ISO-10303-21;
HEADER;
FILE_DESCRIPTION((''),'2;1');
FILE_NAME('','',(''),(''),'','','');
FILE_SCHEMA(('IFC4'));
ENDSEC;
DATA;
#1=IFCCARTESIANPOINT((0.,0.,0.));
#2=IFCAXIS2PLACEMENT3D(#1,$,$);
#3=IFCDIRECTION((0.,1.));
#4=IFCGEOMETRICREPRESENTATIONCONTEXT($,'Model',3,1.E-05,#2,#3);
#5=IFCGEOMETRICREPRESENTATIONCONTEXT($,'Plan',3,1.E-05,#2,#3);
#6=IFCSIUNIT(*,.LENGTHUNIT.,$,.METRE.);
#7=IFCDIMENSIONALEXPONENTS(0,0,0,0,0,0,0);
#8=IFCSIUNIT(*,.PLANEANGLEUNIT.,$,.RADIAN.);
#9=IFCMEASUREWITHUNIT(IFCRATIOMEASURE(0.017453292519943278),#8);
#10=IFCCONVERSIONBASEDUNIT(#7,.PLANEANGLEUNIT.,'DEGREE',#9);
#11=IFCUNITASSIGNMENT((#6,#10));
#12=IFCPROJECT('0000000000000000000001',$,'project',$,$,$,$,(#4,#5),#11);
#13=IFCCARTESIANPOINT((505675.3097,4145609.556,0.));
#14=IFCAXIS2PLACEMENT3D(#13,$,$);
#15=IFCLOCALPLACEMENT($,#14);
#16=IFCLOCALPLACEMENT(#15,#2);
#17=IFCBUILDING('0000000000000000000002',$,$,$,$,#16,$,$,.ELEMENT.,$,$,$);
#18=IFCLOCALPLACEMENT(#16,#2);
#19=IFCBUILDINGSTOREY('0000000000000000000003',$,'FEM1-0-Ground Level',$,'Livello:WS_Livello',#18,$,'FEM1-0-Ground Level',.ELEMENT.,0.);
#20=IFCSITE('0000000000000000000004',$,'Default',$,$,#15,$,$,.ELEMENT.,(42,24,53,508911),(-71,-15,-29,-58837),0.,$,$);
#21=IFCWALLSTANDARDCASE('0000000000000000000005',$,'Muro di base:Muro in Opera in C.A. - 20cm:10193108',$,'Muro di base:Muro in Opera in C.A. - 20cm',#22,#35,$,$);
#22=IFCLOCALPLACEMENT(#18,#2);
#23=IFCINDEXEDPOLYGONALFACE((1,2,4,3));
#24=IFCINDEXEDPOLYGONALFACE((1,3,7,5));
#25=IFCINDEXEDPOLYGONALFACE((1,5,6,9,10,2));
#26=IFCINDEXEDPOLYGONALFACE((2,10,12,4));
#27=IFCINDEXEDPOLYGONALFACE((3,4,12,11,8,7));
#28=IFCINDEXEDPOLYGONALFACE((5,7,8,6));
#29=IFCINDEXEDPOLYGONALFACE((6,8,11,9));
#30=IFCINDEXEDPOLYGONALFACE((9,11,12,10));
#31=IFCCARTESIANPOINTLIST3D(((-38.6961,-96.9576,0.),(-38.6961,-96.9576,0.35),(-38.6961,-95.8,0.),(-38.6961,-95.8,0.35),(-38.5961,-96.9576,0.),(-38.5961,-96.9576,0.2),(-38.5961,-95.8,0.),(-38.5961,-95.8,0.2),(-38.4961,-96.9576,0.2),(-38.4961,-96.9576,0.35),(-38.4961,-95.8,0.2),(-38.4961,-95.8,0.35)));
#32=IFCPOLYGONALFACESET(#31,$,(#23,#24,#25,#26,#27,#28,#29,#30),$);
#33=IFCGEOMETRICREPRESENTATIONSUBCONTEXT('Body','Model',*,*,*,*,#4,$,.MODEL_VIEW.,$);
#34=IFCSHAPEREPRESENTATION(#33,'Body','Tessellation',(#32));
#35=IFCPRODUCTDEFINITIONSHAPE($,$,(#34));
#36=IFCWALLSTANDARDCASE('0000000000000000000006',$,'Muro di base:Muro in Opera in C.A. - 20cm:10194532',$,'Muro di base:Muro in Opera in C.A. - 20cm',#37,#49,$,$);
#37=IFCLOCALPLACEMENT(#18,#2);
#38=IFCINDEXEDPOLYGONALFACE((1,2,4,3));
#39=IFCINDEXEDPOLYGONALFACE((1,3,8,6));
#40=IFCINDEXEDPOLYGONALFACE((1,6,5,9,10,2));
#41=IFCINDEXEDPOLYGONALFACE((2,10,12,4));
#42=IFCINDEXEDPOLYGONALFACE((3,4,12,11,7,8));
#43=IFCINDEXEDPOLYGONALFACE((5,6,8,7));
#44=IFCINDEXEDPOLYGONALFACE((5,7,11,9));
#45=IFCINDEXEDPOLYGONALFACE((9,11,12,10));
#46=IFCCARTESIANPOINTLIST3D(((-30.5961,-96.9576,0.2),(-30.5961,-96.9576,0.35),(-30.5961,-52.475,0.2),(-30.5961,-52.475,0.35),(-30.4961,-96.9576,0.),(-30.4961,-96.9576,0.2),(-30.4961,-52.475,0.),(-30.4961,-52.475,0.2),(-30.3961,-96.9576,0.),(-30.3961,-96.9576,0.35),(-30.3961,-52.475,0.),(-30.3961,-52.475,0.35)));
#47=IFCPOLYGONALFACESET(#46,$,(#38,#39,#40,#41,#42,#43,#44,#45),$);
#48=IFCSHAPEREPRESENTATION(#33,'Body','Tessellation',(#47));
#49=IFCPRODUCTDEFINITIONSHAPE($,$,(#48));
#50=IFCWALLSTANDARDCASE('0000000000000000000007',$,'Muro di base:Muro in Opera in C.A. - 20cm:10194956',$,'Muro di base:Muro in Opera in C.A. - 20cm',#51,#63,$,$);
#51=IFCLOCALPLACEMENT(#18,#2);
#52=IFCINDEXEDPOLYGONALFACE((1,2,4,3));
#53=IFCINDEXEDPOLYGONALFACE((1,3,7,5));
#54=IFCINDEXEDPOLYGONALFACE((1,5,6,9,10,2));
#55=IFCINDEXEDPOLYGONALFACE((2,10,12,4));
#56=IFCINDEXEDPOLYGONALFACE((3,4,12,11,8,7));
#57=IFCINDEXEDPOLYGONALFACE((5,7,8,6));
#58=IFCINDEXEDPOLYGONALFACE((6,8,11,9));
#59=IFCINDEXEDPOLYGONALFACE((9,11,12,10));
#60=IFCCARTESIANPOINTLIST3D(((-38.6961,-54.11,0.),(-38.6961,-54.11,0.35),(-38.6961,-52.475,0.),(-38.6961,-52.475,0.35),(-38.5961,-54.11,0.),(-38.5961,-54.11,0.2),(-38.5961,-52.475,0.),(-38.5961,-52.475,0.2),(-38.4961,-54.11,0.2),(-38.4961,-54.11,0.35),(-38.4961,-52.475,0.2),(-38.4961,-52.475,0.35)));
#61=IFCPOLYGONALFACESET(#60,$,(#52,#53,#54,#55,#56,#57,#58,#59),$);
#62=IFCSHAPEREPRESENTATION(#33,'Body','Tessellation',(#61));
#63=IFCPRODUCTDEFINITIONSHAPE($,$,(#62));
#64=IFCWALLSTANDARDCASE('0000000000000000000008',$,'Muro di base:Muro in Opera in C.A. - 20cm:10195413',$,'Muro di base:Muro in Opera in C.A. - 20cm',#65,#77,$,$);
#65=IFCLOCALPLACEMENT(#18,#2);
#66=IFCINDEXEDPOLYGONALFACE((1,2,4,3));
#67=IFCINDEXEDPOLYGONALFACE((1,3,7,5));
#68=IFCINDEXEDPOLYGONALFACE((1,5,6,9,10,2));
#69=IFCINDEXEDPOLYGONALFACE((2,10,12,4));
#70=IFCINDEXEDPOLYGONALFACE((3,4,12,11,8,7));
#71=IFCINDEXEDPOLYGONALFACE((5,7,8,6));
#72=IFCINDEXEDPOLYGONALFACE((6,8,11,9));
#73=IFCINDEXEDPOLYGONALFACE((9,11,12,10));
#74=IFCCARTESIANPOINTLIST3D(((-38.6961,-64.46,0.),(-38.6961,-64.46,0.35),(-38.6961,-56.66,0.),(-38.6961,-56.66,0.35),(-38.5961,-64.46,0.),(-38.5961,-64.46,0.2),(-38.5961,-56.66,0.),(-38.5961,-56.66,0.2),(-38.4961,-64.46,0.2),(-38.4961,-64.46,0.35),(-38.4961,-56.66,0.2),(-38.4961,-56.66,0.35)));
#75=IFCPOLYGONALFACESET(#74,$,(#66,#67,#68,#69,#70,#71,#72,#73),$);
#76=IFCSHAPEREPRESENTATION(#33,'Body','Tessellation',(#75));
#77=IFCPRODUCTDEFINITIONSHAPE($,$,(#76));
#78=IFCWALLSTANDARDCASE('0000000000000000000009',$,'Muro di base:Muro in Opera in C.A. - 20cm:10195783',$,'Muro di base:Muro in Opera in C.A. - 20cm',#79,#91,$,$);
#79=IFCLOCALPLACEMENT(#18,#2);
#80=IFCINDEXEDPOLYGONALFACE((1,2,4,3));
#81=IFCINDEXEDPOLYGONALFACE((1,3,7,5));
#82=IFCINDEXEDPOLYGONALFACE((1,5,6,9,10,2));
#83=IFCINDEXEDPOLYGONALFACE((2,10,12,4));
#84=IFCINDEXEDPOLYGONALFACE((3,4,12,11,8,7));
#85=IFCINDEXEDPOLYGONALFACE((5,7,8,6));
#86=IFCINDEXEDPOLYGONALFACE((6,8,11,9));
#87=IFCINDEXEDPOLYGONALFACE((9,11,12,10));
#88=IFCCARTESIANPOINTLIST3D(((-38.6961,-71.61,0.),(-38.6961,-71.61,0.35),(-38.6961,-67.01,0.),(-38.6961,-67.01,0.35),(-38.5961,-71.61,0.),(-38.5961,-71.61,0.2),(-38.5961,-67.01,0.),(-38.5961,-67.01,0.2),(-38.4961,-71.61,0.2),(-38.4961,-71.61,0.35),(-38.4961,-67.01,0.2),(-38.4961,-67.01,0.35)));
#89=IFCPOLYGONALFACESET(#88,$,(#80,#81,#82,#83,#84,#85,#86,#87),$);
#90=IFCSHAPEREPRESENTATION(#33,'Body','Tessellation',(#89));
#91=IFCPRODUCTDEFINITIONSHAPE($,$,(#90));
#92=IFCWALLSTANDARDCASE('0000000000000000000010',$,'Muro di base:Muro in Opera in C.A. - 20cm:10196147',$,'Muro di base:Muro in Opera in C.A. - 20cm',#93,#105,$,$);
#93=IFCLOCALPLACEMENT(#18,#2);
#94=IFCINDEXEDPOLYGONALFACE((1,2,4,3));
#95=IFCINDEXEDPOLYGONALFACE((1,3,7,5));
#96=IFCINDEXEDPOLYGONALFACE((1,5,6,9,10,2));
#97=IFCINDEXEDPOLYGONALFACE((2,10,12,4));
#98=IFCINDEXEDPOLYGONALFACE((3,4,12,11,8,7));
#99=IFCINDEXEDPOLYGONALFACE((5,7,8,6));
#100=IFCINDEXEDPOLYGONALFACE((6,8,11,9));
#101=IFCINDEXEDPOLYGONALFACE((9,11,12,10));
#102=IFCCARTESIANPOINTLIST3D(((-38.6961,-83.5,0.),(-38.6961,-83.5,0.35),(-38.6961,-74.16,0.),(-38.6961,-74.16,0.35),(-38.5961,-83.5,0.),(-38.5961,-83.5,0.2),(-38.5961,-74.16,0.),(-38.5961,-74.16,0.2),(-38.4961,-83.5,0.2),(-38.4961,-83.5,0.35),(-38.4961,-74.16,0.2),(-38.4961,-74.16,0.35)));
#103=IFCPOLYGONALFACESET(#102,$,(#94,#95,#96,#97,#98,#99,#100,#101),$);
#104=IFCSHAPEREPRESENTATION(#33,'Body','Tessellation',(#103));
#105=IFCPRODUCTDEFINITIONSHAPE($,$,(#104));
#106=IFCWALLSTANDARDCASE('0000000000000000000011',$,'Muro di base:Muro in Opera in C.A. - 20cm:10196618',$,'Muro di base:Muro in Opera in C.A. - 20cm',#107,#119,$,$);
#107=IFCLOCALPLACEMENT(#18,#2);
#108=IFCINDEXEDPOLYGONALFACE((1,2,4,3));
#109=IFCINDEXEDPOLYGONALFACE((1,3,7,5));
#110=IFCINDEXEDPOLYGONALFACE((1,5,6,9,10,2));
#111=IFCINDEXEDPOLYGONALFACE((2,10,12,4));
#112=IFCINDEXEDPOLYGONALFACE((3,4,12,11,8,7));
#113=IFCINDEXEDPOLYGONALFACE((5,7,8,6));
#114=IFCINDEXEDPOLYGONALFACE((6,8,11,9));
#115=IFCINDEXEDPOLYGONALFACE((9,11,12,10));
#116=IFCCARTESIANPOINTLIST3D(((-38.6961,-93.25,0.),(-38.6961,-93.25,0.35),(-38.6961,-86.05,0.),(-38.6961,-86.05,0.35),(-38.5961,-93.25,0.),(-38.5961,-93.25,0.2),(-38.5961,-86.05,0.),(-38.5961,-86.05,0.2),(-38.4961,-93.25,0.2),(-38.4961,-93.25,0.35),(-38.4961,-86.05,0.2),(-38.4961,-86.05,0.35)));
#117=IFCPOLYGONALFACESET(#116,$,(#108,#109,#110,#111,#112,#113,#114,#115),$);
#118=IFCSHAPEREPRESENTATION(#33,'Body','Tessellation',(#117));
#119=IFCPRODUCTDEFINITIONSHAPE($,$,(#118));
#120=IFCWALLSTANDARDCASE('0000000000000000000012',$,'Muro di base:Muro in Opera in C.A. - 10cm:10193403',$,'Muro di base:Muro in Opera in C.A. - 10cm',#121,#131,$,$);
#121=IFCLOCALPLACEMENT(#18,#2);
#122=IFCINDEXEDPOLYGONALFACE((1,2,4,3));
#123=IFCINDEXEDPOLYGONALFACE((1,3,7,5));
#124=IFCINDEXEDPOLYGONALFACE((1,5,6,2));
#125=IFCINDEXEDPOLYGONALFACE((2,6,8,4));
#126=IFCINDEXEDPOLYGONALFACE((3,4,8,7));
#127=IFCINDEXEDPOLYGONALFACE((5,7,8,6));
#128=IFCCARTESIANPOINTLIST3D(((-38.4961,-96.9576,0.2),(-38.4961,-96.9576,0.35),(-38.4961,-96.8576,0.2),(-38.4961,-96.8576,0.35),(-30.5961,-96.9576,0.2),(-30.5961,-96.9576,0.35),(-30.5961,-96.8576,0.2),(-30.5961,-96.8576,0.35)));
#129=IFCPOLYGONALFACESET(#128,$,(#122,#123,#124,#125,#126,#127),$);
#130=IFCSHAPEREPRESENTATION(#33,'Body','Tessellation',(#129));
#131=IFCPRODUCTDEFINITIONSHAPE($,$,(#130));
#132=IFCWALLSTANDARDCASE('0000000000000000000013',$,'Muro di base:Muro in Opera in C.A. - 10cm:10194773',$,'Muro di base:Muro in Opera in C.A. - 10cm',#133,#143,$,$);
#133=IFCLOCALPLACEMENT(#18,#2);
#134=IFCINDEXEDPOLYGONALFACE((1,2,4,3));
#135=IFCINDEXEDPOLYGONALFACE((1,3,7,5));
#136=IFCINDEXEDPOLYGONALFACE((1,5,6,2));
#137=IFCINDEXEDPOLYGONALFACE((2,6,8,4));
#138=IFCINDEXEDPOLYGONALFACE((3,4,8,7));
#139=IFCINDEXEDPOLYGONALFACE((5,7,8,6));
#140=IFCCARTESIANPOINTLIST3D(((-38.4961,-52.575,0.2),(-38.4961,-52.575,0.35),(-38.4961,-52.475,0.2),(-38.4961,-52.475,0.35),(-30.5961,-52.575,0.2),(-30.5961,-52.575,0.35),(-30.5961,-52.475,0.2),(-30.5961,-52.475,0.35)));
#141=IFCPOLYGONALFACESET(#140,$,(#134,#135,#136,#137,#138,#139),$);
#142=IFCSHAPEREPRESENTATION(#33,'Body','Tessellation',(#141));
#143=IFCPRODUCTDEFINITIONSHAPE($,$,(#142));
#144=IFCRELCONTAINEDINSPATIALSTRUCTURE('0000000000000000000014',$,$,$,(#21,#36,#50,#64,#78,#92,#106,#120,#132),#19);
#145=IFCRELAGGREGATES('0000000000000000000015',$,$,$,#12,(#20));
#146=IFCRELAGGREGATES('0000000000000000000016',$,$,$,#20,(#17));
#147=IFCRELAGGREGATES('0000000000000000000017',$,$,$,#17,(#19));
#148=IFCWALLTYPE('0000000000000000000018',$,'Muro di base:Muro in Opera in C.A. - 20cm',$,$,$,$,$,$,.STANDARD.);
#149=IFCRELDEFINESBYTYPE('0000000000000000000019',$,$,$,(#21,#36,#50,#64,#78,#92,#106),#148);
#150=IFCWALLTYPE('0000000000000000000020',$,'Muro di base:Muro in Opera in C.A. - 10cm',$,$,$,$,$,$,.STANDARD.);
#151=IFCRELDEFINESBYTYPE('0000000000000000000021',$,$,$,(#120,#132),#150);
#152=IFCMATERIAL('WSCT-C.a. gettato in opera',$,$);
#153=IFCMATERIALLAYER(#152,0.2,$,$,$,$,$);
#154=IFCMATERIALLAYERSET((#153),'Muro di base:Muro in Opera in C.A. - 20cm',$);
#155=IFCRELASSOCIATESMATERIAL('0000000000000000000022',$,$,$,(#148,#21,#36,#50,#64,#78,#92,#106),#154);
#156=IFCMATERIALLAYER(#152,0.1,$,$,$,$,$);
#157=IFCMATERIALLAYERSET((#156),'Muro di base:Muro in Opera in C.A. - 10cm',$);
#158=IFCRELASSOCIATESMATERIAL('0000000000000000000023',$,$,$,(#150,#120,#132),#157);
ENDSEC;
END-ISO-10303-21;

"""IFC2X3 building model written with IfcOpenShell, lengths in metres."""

from ifc_helpers import new_model, entity, si_unit, converted_unit, direction, frame, frame_2d, origin, place, context, subcontext, project, spatial, polyline, rectangle, extrude, clip, bounded_halfspace, material, layer, layer_set, layer_usage, type_object, element, save


model = new_model("IFC2X3")

# Units and contexts
model_context = context("Model", 3, precision=1e-05, world=origin(), true_north=direction((0.0, 1.0)))
plan_context = context("Plan", 3, precision=1e-05, world=origin(), true_north=direction((0.0, 1.0)))
body_context = subcontext(model_context, "Body", "Model", "MODEL_VIEW")
ifc_project = project(units=[si_unit("LENGTHUNIT", "METRE"), converted_unit("PLANEANGLEUNIT", "DEGREE", entity("IfcRatioMeasure", 0.017453292519943278), si_unit("PLANEANGLEUNIT", "RADIAN"), dimensions=[0, 0, 0, 0, 0, 0, 0])], contexts=[model_context, plan_context])

# Site, building, storey
site_placement = place(None, frame((505675.3097, 4145609.556, 0.0)))
site = spatial("IfcSite", under=ifc_project, at=site_placement, Name="Default", CompositionType="ELEMENT", RefLatitude=(42, 24, 53, 508911), RefLongitude=(-71, -15, -29, -58837), RefElevation=0.0)
building_placement = place(site_placement, origin())
building = spatial("IfcBuilding", under=site, at=building_placement, CompositionType="ELEMENT")
storey_placement = place(building_placement, origin())
storey = spatial("IfcBuildingStorey", under=building, at=storey_placement, Name="FEM1-0-Ground Level", ObjectType="Livello:WS_Livello", LongName="FEM1-0-Ground Level", CompositionType="ELEMENT", Elevation=0.0)

# Walls
ifc_material = material(Name="WSCT-C.a. gettato in opera")
ifc_layer_1 = layer(ifc_material, 0.2)
ifc_layer_set_1 = layer_set([ifc_layer_1], Name="Muro di base:Muro in Opera in C.A. - 20cm")
ifc_layer_usage_1 = layer_usage(ifc_layer_set_1, "AXIS2", "POSITIVE", -0.1)
wall_type_1 = type_object("IfcWallType", Name="Muro di base:Muro in Opera in C.A. - 20cm", PredefinedType="STANDARD", material=ifc_layer_set_1)
wall_1_placement = place(storey_placement, frame((-38.5961, -95.8, 0.0), z_axis=(0.0, 0.0, 1.0), x_axis=(0.0, -1.0, 0.0)))
element("IfcWallStandardCase", 1, at=wall_1_placement, inside=storey, type_object=wall_type_1, material=ifc_layer_usage_1, Name="Muro di base:Muro in Opera in C.A. - 20cm:10193108", ObjectType="Muro di base:Muro in Opera in C.A. - 20cm", context=body_context, shape_type="Clipping", body=[
    clip(clip(extrude(rectangle(XDim=1.1576, YDim=0.2, at=frame_2d((0.5788, 0.0), x_axis=(-1.0, 0.0))), origin(), (0.0, 0.0, 1.0), 0.35), bounded_halfspace(frame((1.1576, 0.0, 0.2), z_axis=(0.0, 0.0, 1.0), x_axis=(0.0, 1.0, 0.0)), True, frame((1.1576, 0.0, 0.2), z_axis=(0.0, 0.0, 1.0), x_axis=(0.0, 1.0, 0.0)), polyline([(0.0, 0.0), (0.1, 0.0), (0.1, 0.1), (0.1, 1.1576), (0.0, 1.1576), (0.0, 0.0)]))), bounded_halfspace(frame((0.0, 0.0, 0.2), z_axis=(0.0, -1.0, 0.0), x_axis=(0.0, 0.0, 1.0)), True, frame((0.0, 0.0, 0.2), z_axis=(0.0, -1.0, 0.0), x_axis=(0.0, 0.0, 1.0)), polyline([(0.0, 0.0), (-0.2, 0.0), (-0.2, -1.1576), (0.0, -1.1576), (0.0, 0.0)]))),
])
wall_2_placement = place(storey_placement, frame((-30.4961, -96.9576, 0.0), z_axis=(0.0, 0.0, 1.0), x_axis=(0.0, 1.0, 0.0)))
element("IfcWallStandardCase", 2, at=wall_2_placement, inside=storey, type_object=wall_type_1, material=ifc_layer_usage_1, Name="Muro di base:Muro in Opera in C.A. - 20cm:10194532", ObjectType="Muro di base:Muro in Opera in C.A. - 20cm", context=body_context, shape_type="Clipping", body=[
    clip(clip(extrude(rectangle(XDim=44.4826, YDim=0.2, at=frame_2d((22.2413, 0.0), x_axis=(-1.0, 0.0))), origin(), (0.0, 0.0, 1.0), 0.35), bounded_halfspace(frame((44.4826, 0.0, 0.2)), True, frame((44.4826, 0.0, 0.2)), polyline([(0.0, 0.0), (0.0, 0.1), (-0.1, 0.1), (-44.3826, 0.1), (-44.4826, 0.1), (-44.4826, 0.0), (0.0, 0.0)]))), bounded_halfspace(frame((0.0, 0.0, 0.2), z_axis=(0.0, -1.0, 0.0), x_axis=(0.0, 0.0, 1.0)), True, frame((0.0, 0.0, 0.2), z_axis=(0.0, -1.0, 0.0), x_axis=(0.0, 0.0, 1.0)), polyline([(0.0, 0.0), (-0.2, 0.0), (-0.2, -44.4826), (0.0, -44.4826), (0.0, 0.0)]))),
])
wall_3_placement = place(storey_placement, frame((-38.5961, -52.475, 0.0), z_axis=(0.0, 0.0, 1.0), x_axis=(0.0, -1.0, 0.0)))
element("IfcWallStandardCase", 3, at=wall_3_placement, inside=storey, type_object=wall_type_1, material=ifc_layer_usage_1, Name="Muro di base:Muro in Opera in C.A. - 20cm:10194956", ObjectType="Muro di base:Muro in Opera in C.A. - 20cm", context=body_context, shape_type="Clipping", body=[
    clip(clip(extrude(rectangle(XDim=1.635, YDim=0.2, at=frame_2d((0.8175, 0.0), x_axis=(-1.0, 0.0))), origin(), (0.0, 0.0, 1.0), 0.35), bounded_halfspace(frame((1.635, 0.0, 0.2), z_axis=(0.0, 0.0, 1.0), x_axis=(0.0, 1.0, 0.0)), True, frame((1.635, 0.0, 0.2), z_axis=(0.0, 0.0, 1.0), x_axis=(0.0, 1.0, 0.0)), polyline([(0.0, 0.0), (0.1, 0.0), (0.1, 1.535), (0.1, 1.635), (0.0, 1.635), (0.0, 0.0)]))), bounded_halfspace(frame((0.0, 0.0, 0.2), z_axis=(0.0, -1.0, 0.0), x_axis=(0.0, 0.0, 1.0)), True, frame((0.0, 0.0, 0.2), z_axis=(0.0, -1.0, 0.0), x_axis=(0.0, 0.0, 1.0)), polyline([(0.0, 0.0), (-0.2, 0.0), (-0.2, -1.635), (0.0, -1.635), (0.0, 0.0)]))),
])
wall_4_placement = place(storey_placement, frame((-38.5961, -56.66, 0.0), z_axis=(0.0, 0.0, 1.0), x_axis=(0.0, -1.0, 0.0)))
element("IfcWallStandardCase", 4, at=wall_4_placement, inside=storey, type_object=wall_type_1, material=ifc_layer_usage_1, Name="Muro di base:Muro in Opera in C.A. - 20cm:10195413", ObjectType="Muro di base:Muro in Opera in C.A. - 20cm", context=body_context, shape_type="Clipping", body=[
    clip(clip(extrude(rectangle(XDim=7.8, YDim=0.2, at=frame_2d((3.9, 0.0), x_axis=(-1.0, 0.0))), origin(), (0.0, 0.0, 1.0), 0.35), bounded_halfspace(frame((7.8, 0.0, 0.2), z_axis=(0.0, 0.0, 1.0), x_axis=(0.0, 1.0, 0.0)), True, frame((7.8, 0.0, 0.2), z_axis=(0.0, 0.0, 1.0), x_axis=(0.0, 1.0, 0.0)), polyline([(0.0, 0.0), (0.1, 0.0), (0.1, 7.8), (0.0, 7.8), (0.0, 0.0)]))), bounded_halfspace(frame((0.0, 0.0, 0.2), z_axis=(0.0, -1.0, 0.0), x_axis=(0.0, 0.0, 1.0)), True, frame((0.0, 0.0, 0.2), z_axis=(0.0, -1.0, 0.0), x_axis=(0.0, 0.0, 1.0)), polyline([(0.0, 0.0), (-0.2, 0.0), (-0.2, -7.8), (0.0, -7.8), (0.0, 0.0)]))),
])
wall_5_placement = place(storey_placement, frame((-38.5961, -67.01, 0.0), z_axis=(0.0, 0.0, 1.0), x_axis=(0.0, -1.0, 0.0)))
element("IfcWallStandardCase", 5, at=wall_5_placement, inside=storey, type_object=wall_type_1, material=ifc_layer_usage_1, Name="Muro di base:Muro in Opera in C.A. - 20cm:10195783", ObjectType="Muro di base:Muro in Opera in C.A. - 20cm", context=body_context, shape_type="Clipping", body=[
    clip(clip(extrude(rectangle(XDim=4.6, YDim=0.2, at=frame_2d((2.3, 0.0), x_axis=(-1.0, 0.0))), origin(), (0.0, 0.0, 1.0), 0.35), bounded_halfspace(frame((4.6, 0.0, 0.2), z_axis=(0.0, 0.0, 1.0), x_axis=(0.0, 1.0, 0.0)), True, frame((4.6, 0.0, 0.2), z_axis=(0.0, 0.0, 1.0), x_axis=(0.0, 1.0, 0.0)), polyline([(0.0, 0.0), (0.1, 0.0), (0.1, 4.6), (0.0, 4.6), (0.0, 0.0)]))), bounded_halfspace(frame((0.0, 0.0, 0.2), z_axis=(0.0, -1.0, 0.0), x_axis=(0.0, 0.0, 1.0)), True, frame((0.0, 0.0, 0.2), z_axis=(0.0, -1.0, 0.0), x_axis=(0.0, 0.0, 1.0)), polyline([(0.0, 0.0), (-0.2, 0.0), (-0.2, -4.6), (0.0, -4.6), (0.0, 0.0)]))),
])
wall_6_placement = place(storey_placement, frame((-38.5961, -74.16, 0.0), z_axis=(0.0, 0.0, 1.0), x_axis=(0.0, -1.0, 0.0)))
element("IfcWallStandardCase", 6, at=wall_6_placement, inside=storey, type_object=wall_type_1, material=ifc_layer_usage_1, Name="Muro di base:Muro in Opera in C.A. - 20cm:10196147", ObjectType="Muro di base:Muro in Opera in C.A. - 20cm", context=body_context, shape_type="Clipping", body=[
    clip(clip(extrude(rectangle(XDim=9.34, YDim=0.2, at=frame_2d((4.67, 0.0), x_axis=(-1.0, 0.0))), origin(), (0.0, 0.0, 1.0), 0.35), bounded_halfspace(frame((9.34, 0.0, 0.2), z_axis=(0.0, 0.0, 1.0), x_axis=(0.0, 1.0, 0.0)), True, frame((9.34, 0.0, 0.2), z_axis=(0.0, 0.0, 1.0), x_axis=(0.0, 1.0, 0.0)), polyline([(0.0, 0.0), (0.1, 0.0), (0.1, 9.34), (0.0, 9.34), (0.0, 0.0)]))), bounded_halfspace(frame((0.0, 0.0, 0.2), z_axis=(0.0, -1.0, 0.0), x_axis=(0.0, 0.0, 1.0)), True, frame((0.0, 0.0, 0.2), z_axis=(0.0, -1.0, 0.0), x_axis=(0.0, 0.0, 1.0)), polyline([(0.0, 0.0), (-0.2, 0.0), (-0.2, -9.34), (0.0, -9.34), (0.0, 0.0)]))),
])
wall_7_placement = place(storey_placement, frame((-38.5961, -86.05, 0.0), z_axis=(0.0, 0.0, 1.0), x_axis=(0.0, -1.0, 0.0)))
element("IfcWallStandardCase", 7, at=wall_7_placement, inside=storey, type_object=wall_type_1, material=ifc_layer_usage_1, Name="Muro di base:Muro in Opera in C.A. - 20cm:10196618", ObjectType="Muro di base:Muro in Opera in C.A. - 20cm", context=body_context, shape_type="Clipping", body=[
    clip(clip(extrude(rectangle(XDim=7.2, YDim=0.2, at=frame_2d((3.6, 0.0), x_axis=(-1.0, 0.0))), origin(), (0.0, 0.0, 1.0), 0.35), bounded_halfspace(frame((7.2, 0.0, 0.2), z_axis=(0.0, 0.0, 1.0), x_axis=(0.0, 1.0, 0.0)), True, frame((7.2, 0.0, 0.2), z_axis=(0.0, 0.0, 1.0), x_axis=(0.0, 1.0, 0.0)), polyline([(0.0, 0.0), (0.1, 0.0), (0.1, 7.2), (0.0, 7.2), (0.0, 0.0)]))), bounded_halfspace(frame((0.0, 0.0, 0.2), z_axis=(0.0, -1.0, 0.0), x_axis=(0.0, 0.0, 1.0)), True, frame((0.0, 0.0, 0.2), z_axis=(0.0, -1.0, 0.0), x_axis=(0.0, 0.0, 1.0)), polyline([(0.0, 0.0), (-0.2, 0.0), (-0.2, -7.2), (0.0, -7.2), (0.0, 0.0)]))),
])
ifc_layer_2 = layer(ifc_material, 0.1)
ifc_layer_set_2 = layer_set([ifc_layer_2], Name="Muro di base:Muro in Opera in C.A. - 10cm")
ifc_layer_usage_2 = layer_usage(ifc_layer_set_2, "AXIS2", "NEGATIVE", 0.05)
wall_type_2 = type_object("IfcWallType", Name="Muro di base:Muro in Opera in C.A. - 10cm", PredefinedType="STANDARD", material=ifc_layer_set_2)
wall_8_placement = place(storey_placement, frame((-38.4961, -96.9076, 0.2)))
element("IfcWallStandardCase", 8, at=wall_8_placement, inside=storey, type_object=wall_type_2, material=ifc_layer_usage_2, Name="Muro di base:Muro in Opera in C.A. - 10cm:10193403", ObjectType="Muro di base:Muro in Opera in C.A. - 10cm", context=body_context, shape_type="SweptSolid", body=[
    extrude(rectangle(XDim=7.9, YDim=0.1, at=frame_2d((3.95, 0.0), x_axis=(-1.0, 0.0))), origin(), (0.0, 0.0, 1.0), 0.15),
])
wall_9_placement = place(storey_placement, frame((-30.5961, -52.525, 0.2), z_axis=(0.0, 0.0, 1.0), x_axis=(-1.0, 0.0, 0.0)))
element("IfcWallStandardCase", 9, at=wall_9_placement, inside=storey, type_object=wall_type_2, material=ifc_layer_usage_2, Name="Muro di base:Muro in Opera in C.A. - 10cm:10194773", ObjectType="Muro di base:Muro in Opera in C.A. - 10cm", context=body_context, shape_type="SweptSolid", body=[
    extrude(rectangle(XDim=7.9, YDim=0.1, at=frame_2d((3.95, 0.0), x_axis=(-1.0, 0.0))), origin(), (0.0, 0.0, 1.0), 0.15),
])

save(model, "model.ifc")
